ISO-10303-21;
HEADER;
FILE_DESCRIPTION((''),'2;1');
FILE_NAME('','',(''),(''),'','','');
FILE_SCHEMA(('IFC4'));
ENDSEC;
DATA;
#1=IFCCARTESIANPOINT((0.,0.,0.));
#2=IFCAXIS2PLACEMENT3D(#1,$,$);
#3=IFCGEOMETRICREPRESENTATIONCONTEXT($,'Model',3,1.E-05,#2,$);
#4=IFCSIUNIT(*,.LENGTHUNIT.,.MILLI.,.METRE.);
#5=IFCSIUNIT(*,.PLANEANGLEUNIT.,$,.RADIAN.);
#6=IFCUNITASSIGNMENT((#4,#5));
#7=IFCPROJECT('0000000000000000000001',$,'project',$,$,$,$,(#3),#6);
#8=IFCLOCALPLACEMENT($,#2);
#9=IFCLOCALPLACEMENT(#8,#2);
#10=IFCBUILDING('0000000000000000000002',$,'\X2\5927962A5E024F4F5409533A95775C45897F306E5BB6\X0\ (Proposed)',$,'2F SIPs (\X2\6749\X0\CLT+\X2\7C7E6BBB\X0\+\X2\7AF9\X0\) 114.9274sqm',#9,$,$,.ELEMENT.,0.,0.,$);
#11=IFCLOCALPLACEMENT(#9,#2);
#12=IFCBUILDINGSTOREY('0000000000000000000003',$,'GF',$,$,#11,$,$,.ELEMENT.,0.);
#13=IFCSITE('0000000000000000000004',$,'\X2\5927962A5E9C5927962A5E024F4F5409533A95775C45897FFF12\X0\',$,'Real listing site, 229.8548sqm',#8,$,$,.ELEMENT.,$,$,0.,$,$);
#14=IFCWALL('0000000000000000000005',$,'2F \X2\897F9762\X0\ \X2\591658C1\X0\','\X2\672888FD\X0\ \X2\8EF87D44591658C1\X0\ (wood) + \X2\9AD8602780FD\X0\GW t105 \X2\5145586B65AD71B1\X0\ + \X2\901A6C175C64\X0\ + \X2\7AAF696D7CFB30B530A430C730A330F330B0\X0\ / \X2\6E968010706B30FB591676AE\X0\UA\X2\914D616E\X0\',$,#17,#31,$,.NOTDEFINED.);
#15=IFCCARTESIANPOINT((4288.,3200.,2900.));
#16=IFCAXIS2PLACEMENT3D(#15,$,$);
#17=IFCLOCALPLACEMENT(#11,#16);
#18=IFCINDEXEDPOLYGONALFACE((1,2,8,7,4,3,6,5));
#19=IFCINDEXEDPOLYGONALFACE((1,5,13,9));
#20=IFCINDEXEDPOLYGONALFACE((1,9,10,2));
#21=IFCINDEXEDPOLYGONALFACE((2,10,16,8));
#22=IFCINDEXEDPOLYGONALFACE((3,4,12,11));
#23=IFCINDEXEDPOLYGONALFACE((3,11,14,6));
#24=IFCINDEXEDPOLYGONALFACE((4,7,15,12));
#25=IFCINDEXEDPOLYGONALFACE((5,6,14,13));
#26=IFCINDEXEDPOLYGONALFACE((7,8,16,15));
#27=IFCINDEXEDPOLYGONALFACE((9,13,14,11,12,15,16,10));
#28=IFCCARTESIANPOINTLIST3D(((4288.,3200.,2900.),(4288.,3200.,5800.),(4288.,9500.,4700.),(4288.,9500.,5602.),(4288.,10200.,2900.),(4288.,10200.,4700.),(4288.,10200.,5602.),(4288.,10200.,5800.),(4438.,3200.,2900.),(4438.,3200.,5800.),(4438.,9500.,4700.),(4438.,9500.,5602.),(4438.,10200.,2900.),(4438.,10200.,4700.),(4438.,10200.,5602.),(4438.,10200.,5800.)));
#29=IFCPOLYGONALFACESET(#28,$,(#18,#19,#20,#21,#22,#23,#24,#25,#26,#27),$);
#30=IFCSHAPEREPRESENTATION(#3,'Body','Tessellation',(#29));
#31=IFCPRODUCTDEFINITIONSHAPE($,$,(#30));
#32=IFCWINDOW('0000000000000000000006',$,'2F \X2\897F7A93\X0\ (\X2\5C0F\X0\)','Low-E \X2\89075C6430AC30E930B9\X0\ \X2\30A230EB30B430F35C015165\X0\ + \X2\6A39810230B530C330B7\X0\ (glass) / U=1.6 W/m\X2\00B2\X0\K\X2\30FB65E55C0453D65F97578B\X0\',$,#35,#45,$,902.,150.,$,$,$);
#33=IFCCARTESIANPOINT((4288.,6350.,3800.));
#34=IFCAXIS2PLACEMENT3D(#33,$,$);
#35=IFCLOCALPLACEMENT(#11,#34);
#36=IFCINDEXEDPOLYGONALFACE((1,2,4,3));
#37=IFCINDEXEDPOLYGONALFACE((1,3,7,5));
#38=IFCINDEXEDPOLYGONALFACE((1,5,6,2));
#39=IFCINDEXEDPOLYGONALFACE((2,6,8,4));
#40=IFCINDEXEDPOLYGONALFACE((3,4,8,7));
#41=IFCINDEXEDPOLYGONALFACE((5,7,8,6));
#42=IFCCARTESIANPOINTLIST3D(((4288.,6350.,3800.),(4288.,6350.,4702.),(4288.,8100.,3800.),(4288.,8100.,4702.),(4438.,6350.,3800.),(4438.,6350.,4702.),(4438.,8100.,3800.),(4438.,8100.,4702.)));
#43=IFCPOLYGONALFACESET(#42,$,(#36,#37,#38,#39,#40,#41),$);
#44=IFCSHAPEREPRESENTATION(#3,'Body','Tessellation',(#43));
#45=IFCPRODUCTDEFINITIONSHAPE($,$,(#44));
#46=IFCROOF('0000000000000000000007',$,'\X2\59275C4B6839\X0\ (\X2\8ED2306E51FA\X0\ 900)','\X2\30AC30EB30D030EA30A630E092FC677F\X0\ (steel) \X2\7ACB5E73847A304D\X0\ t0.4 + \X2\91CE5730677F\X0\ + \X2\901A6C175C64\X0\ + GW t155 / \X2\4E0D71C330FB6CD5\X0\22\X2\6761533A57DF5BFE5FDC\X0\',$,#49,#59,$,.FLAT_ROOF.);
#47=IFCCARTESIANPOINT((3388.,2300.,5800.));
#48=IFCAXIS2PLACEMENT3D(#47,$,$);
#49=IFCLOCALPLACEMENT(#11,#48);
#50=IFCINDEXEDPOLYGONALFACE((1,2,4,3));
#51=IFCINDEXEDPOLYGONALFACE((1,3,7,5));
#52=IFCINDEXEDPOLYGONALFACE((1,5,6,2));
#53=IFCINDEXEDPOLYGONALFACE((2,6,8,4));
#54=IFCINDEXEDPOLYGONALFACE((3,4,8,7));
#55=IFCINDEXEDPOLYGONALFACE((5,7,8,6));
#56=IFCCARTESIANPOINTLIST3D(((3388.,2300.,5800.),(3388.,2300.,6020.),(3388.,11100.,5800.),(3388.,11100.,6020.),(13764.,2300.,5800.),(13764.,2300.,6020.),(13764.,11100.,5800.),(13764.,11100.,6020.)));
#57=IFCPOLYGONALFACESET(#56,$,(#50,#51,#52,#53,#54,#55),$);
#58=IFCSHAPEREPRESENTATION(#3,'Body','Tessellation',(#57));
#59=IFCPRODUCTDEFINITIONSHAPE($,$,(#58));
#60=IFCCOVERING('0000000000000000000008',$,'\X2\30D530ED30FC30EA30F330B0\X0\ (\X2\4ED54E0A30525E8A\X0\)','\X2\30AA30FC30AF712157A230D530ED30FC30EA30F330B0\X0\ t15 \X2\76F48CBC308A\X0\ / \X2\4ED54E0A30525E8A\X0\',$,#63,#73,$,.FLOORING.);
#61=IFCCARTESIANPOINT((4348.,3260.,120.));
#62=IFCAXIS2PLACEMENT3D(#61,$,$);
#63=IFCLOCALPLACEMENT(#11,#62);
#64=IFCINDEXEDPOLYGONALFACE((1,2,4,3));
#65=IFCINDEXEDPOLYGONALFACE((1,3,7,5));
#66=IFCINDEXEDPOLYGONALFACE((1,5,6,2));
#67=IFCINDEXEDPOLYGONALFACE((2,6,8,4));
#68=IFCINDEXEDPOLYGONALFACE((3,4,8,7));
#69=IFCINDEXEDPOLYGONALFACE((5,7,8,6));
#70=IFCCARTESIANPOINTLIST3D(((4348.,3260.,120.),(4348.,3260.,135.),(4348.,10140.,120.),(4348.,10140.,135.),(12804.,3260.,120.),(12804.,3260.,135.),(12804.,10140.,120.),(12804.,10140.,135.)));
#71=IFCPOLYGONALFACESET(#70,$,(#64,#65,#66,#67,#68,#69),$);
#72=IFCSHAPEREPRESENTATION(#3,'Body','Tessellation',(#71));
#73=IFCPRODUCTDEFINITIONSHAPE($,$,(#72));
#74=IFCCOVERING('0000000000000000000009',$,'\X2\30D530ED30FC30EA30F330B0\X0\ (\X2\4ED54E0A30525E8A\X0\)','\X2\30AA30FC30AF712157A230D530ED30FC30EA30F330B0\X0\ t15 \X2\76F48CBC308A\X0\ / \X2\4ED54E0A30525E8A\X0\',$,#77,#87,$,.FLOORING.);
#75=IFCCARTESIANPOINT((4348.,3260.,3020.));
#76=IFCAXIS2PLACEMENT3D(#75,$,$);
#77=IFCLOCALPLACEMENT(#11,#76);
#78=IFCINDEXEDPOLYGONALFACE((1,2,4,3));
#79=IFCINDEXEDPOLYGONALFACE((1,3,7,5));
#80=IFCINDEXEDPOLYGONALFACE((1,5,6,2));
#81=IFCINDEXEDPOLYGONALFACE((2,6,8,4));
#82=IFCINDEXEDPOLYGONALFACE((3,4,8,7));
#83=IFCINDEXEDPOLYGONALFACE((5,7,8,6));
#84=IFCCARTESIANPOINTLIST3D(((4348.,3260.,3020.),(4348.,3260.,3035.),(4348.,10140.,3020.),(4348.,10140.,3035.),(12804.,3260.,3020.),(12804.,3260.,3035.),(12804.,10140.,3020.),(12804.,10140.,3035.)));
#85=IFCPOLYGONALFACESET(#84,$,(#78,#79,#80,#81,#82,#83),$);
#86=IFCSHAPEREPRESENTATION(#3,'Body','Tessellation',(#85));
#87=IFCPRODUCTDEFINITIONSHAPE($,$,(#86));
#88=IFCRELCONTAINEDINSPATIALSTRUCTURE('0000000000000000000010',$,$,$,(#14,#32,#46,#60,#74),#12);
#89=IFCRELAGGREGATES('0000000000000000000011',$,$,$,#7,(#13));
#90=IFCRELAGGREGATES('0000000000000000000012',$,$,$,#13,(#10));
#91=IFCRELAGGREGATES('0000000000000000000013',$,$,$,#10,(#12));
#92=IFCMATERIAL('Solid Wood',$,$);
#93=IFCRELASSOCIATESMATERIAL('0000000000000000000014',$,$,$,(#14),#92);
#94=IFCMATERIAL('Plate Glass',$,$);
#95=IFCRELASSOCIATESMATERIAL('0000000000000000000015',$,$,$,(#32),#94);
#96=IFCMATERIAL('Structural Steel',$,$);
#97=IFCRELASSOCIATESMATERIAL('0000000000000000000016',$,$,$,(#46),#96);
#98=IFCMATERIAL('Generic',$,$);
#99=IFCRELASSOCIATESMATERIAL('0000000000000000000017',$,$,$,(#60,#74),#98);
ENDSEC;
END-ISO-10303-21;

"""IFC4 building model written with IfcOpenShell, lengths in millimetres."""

from ifc_helpers import new_model, si_unit, frame, frame_2d, origin, place, context, project, spatial, rectangle, extrude, material, element, fill, save


model = new_model("IFC4")

# Units and contexts
model_context = context("Model", 3, precision=1e-05, world=origin())
ifc_project = project(units=[si_unit("LENGTHUNIT", "METRE", prefix="MILLI"), si_unit("PLANEANGLEUNIT", "RADIAN")], contexts=[model_context])

# Site, building, storey
site_placement = place(None, origin())
site = spatial("IfcSite", under=ifc_project, at=site_placement, Name="大阪府大阪市住吉区長居西２", ObjectType="Real listing site, 229.8548sqm", CompositionType="ELEMENT", RefElevation=0.0)
building_placement = place(site_placement, origin())
building = spatial("IfcBuilding", under=site, at=building_placement, Name="大阪市住吉区長居西の家 (Proposed)", ObjectType="2F SIPs (杉CLT+籾殻+竹) 114.9274sqm", CompositionType="ELEMENT", ElevationOfRefHeight=0.0, ElevationOfTerrain=0.0)
storey_placement = place(building_placement, origin())
storey = spatial("IfcBuildingStorey", under=building, at=storey_placement, Name="GF", CompositionType="ELEMENT", Elevation=0.0)

# Shared definitions
ifc_material_1 = material(Name="Solid Wood")

# Shared definitions
ifc_material_2 = material(Name="Plate Glass")

# Wall, opening, window
wall_1_placement = place(storey_placement, frame((4288.0, 3200.0, 2900.0)))
wall_1 = element("IfcWall", 1, at=wall_1_placement, inside=storey, material=ifc_material_1, Name="2F 西面 外壁", Description="木製 軸組外壁 (wood) + 高性能GW t105 充填断熱 + 通気層 + 窯業系サイディング / 準耐火・外皮UA配慮", PredefinedType="NOTDEFINED", context=model_context, shape_type="SweptSolid", body=[
    extrude(rectangle(XDim=150.0, YDim=7000.0, at=frame_2d((75.0, 3500.0))), frame((4288.0, 3200.0, 2900.0)), (0.0, 0.0, 1.0), 2900.0),
])
opening_1_placement = place(storey_placement, frame((4288.0, 6350.0, 3800.0)))
opening_1 = element("IfcOpeningElement", 2, at=opening_1_placement, cuts=wall_1, PredefinedType="NOTDEFINED", context=model_context, shape_type="SweptSolid", body=[
    extrude(rectangle(XDim=150.0, YDim=1750.0, at=frame_2d((75.0, 875.0))), frame((4288.0, 6350.0, 3800.0)), (0.0, 0.0, 1.0), 902.0),
])
window_1_placement = place(storey_placement, frame((4288.0, 6350.0, 3800.0)))
window_1 = element("IfcWindow", 3, at=window_1_placement, inside=storey, material=ifc_material_2, Name="2F 西窓 (小)", Description="Low-E 複層ガラス アルゴン封入 + 樹脂サッシ (glass) / U=1.6 W/m²K・日射取得型", OverallHeight=902.0, OverallWidth=150.0, context=model_context, shape_type="SweptSolid", body=[
    extrude(rectangle(XDim=150.0, YDim=1750.0, at=frame_2d((75.0, 875.0))), frame((4288.0, 6350.0, 3800.0)), (0.0, 0.0, 1.0), 902.0),
])
fill(opening_1, window_1)

# Roof
ifc_material_3 = material(Name="Structural Steel")
roof_placement = place(storey_placement, frame((3388.0, 2300.0, 5800.0)))
element("IfcRoof", 4, at=roof_placement, inside=storey, material=ifc_material_3, Name="大屋根 (軒の出 900)", Description="ガルバリウム鋼板 (steel) 立平葺き t0.4 + 野地板 + 通気層 + GW t155 / 不燃・法22条区域対応", PredefinedType="FLAT_ROOF", context=model_context, shape_type="SweptSolid", body=[
    extrude(rectangle(XDim=10376.0, YDim=8800.0, at=frame_2d((5188.0, 4400.0))), frame((3388.0, 2300.0, 5800.0)), (0.0, 0.0, 1.0), 220.0),
])

# Coverings
ifc_material_4 = material(Name="Generic")
covering_1_placement = place(storey_placement, frame((4348.0, 3260.0, 120.0)))
element("IfcCovering", 5, at=covering_1_placement, inside=storey, material=ifc_material_4, Name="フローリング (仕上げ床)", Description="オーク無垢フローリング t15 直貼り / 仕上げ床", PredefinedType="FLOORING", context=model_context, shape_type="SweptSolid", body=[
    extrude(rectangle(XDim=8456.0, YDim=6880.0, at=frame_2d((4228.0, 3440.0))), frame((4348.0, 3260.0, 120.0)), (0.0, 0.0, 1.0), 15.0),
])
covering_2_placement = place(storey_placement, frame((4348.0, 3260.0, 3020.0)))
element("IfcCovering", 6, at=covering_2_placement, inside=storey, material=ifc_material_4, Name="フローリング (仕上げ床)", Description="オーク無垢フローリング t15 直貼り / 仕上げ床", PredefinedType="FLOORING", context=model_context, shape_type="SweptSolid", body=[
    extrude(rectangle(XDim=8456.0, YDim=6880.0, at=frame_2d((4228.0, 3440.0))), frame((4348.0, 3260.0, 3020.0)), (0.0, 0.0, 1.0), 15.0),
])

save(model, "model.ifc")
